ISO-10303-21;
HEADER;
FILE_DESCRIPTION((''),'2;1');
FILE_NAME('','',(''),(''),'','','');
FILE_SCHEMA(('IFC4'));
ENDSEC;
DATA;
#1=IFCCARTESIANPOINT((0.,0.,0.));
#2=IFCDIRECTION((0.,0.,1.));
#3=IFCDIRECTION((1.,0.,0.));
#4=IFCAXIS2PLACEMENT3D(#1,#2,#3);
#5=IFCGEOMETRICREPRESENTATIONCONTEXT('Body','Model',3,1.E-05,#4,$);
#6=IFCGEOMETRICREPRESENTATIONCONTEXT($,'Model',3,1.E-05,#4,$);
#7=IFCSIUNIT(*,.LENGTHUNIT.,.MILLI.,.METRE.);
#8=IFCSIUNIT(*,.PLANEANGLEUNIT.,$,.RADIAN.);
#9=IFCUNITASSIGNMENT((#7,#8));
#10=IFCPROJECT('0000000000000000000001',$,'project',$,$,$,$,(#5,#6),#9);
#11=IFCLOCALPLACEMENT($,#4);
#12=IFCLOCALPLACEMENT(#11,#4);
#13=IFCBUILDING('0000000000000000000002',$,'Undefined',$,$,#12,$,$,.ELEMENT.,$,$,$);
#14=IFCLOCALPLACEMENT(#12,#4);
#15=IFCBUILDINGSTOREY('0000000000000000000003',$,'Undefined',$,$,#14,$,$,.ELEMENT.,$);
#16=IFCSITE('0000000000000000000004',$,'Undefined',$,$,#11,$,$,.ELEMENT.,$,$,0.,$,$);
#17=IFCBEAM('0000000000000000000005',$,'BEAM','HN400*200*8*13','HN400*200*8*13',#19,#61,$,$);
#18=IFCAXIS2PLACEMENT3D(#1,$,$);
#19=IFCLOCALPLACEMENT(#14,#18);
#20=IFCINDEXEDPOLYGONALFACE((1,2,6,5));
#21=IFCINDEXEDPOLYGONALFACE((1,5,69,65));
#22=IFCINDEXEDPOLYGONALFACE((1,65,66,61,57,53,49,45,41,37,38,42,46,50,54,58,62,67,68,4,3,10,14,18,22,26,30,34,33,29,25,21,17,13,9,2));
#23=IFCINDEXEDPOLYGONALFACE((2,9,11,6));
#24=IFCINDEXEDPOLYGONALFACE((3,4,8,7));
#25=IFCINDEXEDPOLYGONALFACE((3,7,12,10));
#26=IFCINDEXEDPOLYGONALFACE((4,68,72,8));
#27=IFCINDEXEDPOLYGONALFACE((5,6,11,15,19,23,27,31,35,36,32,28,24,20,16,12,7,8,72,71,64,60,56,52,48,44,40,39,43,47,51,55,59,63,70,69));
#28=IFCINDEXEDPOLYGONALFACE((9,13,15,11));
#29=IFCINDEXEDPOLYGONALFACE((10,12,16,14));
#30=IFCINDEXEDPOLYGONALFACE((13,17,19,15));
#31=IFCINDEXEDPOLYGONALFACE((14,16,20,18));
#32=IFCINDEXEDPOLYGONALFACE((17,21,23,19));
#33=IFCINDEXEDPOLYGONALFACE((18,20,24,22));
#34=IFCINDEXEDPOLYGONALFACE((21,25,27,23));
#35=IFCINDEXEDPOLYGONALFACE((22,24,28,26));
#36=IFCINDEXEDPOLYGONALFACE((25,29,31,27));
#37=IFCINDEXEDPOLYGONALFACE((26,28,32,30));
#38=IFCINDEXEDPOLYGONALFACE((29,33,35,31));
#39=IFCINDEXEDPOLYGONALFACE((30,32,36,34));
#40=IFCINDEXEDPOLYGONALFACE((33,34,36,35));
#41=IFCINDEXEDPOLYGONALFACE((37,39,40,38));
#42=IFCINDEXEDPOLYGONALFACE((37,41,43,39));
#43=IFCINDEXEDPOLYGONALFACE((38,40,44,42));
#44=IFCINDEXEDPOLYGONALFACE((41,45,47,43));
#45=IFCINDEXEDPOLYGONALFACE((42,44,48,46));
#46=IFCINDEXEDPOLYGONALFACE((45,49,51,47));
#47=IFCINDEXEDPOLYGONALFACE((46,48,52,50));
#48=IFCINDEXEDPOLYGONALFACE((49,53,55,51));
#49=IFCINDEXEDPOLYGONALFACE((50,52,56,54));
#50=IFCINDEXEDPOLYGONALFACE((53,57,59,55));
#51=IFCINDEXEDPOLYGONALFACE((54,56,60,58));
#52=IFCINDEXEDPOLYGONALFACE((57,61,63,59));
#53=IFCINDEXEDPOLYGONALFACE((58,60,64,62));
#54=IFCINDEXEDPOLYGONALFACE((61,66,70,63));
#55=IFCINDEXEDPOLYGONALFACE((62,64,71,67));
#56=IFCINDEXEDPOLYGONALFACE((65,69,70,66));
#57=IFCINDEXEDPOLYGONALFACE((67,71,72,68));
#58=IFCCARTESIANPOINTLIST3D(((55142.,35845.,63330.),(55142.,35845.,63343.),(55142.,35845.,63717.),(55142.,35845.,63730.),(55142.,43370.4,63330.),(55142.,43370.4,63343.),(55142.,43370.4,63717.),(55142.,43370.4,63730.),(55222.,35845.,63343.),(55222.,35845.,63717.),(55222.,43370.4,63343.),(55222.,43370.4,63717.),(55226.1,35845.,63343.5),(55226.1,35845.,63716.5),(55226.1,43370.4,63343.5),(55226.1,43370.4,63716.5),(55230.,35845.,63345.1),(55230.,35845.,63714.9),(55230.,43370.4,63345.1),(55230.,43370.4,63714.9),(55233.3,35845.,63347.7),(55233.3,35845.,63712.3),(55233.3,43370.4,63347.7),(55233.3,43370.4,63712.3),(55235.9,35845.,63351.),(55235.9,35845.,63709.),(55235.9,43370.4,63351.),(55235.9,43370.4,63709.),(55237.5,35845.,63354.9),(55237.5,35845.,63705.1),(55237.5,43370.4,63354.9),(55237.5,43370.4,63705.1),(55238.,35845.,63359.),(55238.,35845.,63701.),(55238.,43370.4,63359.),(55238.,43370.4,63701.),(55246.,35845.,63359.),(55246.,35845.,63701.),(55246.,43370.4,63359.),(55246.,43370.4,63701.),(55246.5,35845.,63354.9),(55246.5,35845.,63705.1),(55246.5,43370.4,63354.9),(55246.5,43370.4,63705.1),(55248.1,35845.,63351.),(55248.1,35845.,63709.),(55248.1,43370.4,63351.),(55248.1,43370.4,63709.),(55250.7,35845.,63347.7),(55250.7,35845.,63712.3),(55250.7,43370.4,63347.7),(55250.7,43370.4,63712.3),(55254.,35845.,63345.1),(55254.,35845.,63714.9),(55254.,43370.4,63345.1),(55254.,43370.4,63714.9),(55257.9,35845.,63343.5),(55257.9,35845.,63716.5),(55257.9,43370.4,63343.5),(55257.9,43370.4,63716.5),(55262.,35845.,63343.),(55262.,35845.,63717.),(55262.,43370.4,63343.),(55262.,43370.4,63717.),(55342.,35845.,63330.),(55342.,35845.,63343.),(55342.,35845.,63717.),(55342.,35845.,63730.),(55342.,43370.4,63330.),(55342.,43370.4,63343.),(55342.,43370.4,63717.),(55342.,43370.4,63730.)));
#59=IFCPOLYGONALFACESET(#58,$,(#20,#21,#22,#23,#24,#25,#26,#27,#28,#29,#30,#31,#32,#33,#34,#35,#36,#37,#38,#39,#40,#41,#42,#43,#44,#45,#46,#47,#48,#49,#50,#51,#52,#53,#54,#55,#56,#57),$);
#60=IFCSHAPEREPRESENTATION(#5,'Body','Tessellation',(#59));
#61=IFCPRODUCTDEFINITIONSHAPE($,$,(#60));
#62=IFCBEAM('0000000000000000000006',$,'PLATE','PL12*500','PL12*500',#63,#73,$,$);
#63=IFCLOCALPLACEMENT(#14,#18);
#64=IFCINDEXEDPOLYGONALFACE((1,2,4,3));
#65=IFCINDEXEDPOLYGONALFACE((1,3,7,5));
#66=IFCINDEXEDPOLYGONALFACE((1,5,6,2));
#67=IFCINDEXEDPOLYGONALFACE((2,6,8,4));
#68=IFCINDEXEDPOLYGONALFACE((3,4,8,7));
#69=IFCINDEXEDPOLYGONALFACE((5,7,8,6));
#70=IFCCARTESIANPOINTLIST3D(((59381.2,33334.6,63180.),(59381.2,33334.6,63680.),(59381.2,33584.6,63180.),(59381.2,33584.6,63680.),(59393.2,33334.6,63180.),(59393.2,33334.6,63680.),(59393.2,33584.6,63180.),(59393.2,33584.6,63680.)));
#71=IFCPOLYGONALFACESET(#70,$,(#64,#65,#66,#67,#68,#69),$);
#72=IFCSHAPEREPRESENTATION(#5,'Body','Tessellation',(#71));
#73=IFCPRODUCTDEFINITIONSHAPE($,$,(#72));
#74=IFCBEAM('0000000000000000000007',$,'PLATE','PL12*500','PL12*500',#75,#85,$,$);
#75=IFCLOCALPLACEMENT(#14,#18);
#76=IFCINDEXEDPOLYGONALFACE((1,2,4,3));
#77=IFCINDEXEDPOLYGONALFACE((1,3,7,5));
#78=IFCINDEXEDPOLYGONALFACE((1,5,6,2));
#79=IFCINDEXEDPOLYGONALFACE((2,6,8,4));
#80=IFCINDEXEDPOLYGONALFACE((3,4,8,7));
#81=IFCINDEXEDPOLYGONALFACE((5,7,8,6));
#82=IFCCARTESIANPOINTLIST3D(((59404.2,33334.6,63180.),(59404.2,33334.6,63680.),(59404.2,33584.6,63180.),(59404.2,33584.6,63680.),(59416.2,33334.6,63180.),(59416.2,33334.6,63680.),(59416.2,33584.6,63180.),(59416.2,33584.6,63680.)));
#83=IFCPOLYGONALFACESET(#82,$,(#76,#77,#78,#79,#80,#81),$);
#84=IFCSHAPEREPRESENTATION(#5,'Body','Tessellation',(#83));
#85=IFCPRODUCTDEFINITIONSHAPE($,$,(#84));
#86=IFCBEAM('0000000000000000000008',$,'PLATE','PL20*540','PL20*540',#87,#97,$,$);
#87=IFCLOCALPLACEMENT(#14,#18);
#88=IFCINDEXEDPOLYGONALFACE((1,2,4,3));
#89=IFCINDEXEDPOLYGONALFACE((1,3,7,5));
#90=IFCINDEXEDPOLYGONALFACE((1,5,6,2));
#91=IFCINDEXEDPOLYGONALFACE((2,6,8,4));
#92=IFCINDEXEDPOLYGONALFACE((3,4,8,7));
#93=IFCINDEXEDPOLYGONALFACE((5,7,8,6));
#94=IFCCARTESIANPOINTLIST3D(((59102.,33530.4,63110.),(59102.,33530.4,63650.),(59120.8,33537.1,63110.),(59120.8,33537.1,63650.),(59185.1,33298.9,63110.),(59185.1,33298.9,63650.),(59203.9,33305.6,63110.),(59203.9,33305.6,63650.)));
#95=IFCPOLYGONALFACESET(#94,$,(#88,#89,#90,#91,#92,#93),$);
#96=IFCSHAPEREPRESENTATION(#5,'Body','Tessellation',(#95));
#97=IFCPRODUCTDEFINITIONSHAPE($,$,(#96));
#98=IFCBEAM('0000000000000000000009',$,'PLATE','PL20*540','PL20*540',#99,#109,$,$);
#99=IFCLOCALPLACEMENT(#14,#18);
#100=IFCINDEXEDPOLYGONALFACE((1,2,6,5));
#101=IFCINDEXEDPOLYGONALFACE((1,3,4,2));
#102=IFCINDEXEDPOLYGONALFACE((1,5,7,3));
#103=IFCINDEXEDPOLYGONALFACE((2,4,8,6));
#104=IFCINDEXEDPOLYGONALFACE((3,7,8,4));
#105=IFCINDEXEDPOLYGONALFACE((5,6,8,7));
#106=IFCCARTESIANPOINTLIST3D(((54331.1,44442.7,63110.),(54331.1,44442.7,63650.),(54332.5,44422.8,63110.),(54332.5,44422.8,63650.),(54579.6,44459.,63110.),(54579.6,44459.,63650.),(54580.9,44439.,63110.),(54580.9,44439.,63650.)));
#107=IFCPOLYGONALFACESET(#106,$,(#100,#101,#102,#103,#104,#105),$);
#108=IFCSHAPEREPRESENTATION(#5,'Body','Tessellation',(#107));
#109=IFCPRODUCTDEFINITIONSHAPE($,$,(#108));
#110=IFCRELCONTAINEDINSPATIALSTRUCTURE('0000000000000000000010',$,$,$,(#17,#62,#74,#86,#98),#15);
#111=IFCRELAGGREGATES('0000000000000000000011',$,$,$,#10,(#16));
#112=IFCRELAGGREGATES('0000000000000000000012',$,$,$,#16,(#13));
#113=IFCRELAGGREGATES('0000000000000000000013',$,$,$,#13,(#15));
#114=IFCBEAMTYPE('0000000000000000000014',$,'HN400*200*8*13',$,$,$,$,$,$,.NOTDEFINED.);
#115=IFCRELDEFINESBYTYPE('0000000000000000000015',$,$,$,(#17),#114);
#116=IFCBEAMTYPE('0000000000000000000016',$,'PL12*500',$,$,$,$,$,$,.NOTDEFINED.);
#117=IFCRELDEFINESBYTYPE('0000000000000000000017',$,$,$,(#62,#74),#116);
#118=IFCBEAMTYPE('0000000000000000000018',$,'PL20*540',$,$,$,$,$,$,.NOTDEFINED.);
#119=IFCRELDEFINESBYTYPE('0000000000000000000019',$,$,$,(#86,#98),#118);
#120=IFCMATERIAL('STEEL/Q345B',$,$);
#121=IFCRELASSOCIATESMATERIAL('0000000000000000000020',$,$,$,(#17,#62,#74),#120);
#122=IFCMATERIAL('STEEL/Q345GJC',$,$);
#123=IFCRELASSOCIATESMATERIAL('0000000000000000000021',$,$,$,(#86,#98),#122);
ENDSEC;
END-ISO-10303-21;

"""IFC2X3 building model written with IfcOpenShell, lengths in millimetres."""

from ifc_helpers import new_model, si_unit, frame, origin_with_axes, origin_2d_with_axis, place, context, project, spatial, rectangle, i_section, extrude, material, type_object, element, save


model = new_model("IFC2X3")

# Units and contexts
model_context_1 = context("Model", 3, precision=1e-05, world=origin_with_axes(), identifier="Body")
model_context_2 = context("Model", 3, precision=1e-05, world=origin_with_axes())
ifc_project = project(units=[si_unit("LENGTHUNIT", "METRE", prefix="MILLI"), si_unit("PLANEANGLEUNIT", "RADIAN")], contexts=[model_context_1, model_context_2])

# Site, building, storey
site_placement = place(None, origin_with_axes())
site = spatial("IfcSite", under=ifc_project, at=site_placement, Name="Undefined", CompositionType="ELEMENT", RefElevation=0.0)
building_placement = place(site_placement, origin_with_axes())
building = spatial("IfcBuilding", under=site, at=building_placement, Name="Undefined", CompositionType="ELEMENT")
storey_placement = place(building_placement, origin_with_axes())
storey = spatial("IfcBuildingStorey", under=building, at=storey_placement, Name="Undefined", CompositionType="ELEMENT")

# Beams
ifc_material_1 = material(Name="STEEL/Q345B")
beam_type_1 = type_object("IfcBeamType", Name="HN400*200*8*13", PredefinedType="NOTDEFINED")
beam_1_placement = place(storey_placement, frame((55242.0, 35680.0, 63530.0), z_axis=(0.0, 0.0, 1.0), x_axis=(0.0, 1.0, 0.0)))
element("IfcBeam", 1, at=beam_1_placement, inside=storey, type_object=beam_type_1, material=ifc_material_1, Name="BEAM", Description="HN400*200*8*13", ObjectType="HN400*200*8*13", context=model_context_1, shape_type="SweptSolid", body=[
    extrude(i_section(OverallWidth=200.0, OverallDepth=400.0, WebThickness=8.0, FlangeThickness=13.0, FilletRadius=16.0, at=origin_2d_with_axis()), frame((7690.4, 0.0, 0.0), z_axis=(-1.0, 0.0, 0.0), x_axis=(0.0, -1.0, 0.0)), (0.0, 0.0, 1.0), 7525.4),
])
beam_type_2 = type_object("IfcBeamType", Name="PL12*500", PredefinedType="NOTDEFINED")
for number, where, z_axis, x_axis, name in (
    (2, (59387.2, 33334.6, 63430.0), (0.0, 0.0, 1.0), (0.0, 1.0, 0.0), "PLATE"),
    (3, (59410.2, 33334.6, 63430.0), (0.0, 0.0, 1.0), (0.0, 1.0, 0.0), "PLATE"),
):
    element("IfcBeam", number, at=place(storey_placement, frame(where, z_axis=z_axis, x_axis=x_axis)), inside=storey, type_object=beam_type_2, material=ifc_material_1, Name=name, Description="PL12*500", ObjectType="PL12*500", context=model_context_1, shape_type="SweptSolid", body=[
        extrude(rectangle(XDim=12.0, YDim=500.0, at=origin_2d_with_axis()), frame((250.0, 0.0, 0.0), z_axis=(-1.0, 0.0, 0.0), x_axis=(0.0, -1.0, 0.0)), (0.0, 0.0, 1.0), 250.0),
    ])
ifc_material_2 = material(Name="STEEL/Q345GJC")
beam_type_3 = type_object("IfcBeamType", Name="PL20*540", PredefinedType="NOTDEFINED")
beam_2_placement = place(storey_placement, frame((59194.5, 33302.2, 63380.0), z_axis=(0.0, 0.0, 1.0), x_axis=(-0.337816, 0.941212, 0.0)))
element("IfcBeam", 4, at=beam_2_placement, inside=storey, type_object=beam_type_3, material=ifc_material_2, Name="PLATE", Description="PL20*540", ObjectType="PL20*540", context=model_context_1, shape_type="SweptSolid", body=[
    extrude(rectangle(XDim=20.0, YDim=540.0, at=origin_2d_with_axis()), frame((246.0, 0.0, 0.0), z_axis=(-1.0, 0.0, 0.0), x_axis=(0.0, -1.0, 0.0)), (0.0, 0.0, 1.0), 246.0),
])
beam_3_placement = place(storey_placement, frame((54580.3, 44449.0, 63380.0), z_axis=(0.0, 0.0, 1.0), x_axis=(-0.997873, -0.065183, 0.0)))
element("IfcBeam", 5, at=beam_3_placement, inside=storey, type_object=beam_type_3, material=ifc_material_2, Name="PLATE", Description="PL20*540", ObjectType="PL20*540", context=model_context_1, shape_type="SweptSolid", body=[
    extrude(rectangle(XDim=20.0, YDim=540.0, at=origin_2d_with_axis()), frame((249.0, 0.0, 0.0), z_axis=(-1.0, 0.0, 0.0), x_axis=(0.0, -1.0, 0.0)), (0.0, 0.0, 1.0), 249.0),
])

save(model, "model.ifc")
